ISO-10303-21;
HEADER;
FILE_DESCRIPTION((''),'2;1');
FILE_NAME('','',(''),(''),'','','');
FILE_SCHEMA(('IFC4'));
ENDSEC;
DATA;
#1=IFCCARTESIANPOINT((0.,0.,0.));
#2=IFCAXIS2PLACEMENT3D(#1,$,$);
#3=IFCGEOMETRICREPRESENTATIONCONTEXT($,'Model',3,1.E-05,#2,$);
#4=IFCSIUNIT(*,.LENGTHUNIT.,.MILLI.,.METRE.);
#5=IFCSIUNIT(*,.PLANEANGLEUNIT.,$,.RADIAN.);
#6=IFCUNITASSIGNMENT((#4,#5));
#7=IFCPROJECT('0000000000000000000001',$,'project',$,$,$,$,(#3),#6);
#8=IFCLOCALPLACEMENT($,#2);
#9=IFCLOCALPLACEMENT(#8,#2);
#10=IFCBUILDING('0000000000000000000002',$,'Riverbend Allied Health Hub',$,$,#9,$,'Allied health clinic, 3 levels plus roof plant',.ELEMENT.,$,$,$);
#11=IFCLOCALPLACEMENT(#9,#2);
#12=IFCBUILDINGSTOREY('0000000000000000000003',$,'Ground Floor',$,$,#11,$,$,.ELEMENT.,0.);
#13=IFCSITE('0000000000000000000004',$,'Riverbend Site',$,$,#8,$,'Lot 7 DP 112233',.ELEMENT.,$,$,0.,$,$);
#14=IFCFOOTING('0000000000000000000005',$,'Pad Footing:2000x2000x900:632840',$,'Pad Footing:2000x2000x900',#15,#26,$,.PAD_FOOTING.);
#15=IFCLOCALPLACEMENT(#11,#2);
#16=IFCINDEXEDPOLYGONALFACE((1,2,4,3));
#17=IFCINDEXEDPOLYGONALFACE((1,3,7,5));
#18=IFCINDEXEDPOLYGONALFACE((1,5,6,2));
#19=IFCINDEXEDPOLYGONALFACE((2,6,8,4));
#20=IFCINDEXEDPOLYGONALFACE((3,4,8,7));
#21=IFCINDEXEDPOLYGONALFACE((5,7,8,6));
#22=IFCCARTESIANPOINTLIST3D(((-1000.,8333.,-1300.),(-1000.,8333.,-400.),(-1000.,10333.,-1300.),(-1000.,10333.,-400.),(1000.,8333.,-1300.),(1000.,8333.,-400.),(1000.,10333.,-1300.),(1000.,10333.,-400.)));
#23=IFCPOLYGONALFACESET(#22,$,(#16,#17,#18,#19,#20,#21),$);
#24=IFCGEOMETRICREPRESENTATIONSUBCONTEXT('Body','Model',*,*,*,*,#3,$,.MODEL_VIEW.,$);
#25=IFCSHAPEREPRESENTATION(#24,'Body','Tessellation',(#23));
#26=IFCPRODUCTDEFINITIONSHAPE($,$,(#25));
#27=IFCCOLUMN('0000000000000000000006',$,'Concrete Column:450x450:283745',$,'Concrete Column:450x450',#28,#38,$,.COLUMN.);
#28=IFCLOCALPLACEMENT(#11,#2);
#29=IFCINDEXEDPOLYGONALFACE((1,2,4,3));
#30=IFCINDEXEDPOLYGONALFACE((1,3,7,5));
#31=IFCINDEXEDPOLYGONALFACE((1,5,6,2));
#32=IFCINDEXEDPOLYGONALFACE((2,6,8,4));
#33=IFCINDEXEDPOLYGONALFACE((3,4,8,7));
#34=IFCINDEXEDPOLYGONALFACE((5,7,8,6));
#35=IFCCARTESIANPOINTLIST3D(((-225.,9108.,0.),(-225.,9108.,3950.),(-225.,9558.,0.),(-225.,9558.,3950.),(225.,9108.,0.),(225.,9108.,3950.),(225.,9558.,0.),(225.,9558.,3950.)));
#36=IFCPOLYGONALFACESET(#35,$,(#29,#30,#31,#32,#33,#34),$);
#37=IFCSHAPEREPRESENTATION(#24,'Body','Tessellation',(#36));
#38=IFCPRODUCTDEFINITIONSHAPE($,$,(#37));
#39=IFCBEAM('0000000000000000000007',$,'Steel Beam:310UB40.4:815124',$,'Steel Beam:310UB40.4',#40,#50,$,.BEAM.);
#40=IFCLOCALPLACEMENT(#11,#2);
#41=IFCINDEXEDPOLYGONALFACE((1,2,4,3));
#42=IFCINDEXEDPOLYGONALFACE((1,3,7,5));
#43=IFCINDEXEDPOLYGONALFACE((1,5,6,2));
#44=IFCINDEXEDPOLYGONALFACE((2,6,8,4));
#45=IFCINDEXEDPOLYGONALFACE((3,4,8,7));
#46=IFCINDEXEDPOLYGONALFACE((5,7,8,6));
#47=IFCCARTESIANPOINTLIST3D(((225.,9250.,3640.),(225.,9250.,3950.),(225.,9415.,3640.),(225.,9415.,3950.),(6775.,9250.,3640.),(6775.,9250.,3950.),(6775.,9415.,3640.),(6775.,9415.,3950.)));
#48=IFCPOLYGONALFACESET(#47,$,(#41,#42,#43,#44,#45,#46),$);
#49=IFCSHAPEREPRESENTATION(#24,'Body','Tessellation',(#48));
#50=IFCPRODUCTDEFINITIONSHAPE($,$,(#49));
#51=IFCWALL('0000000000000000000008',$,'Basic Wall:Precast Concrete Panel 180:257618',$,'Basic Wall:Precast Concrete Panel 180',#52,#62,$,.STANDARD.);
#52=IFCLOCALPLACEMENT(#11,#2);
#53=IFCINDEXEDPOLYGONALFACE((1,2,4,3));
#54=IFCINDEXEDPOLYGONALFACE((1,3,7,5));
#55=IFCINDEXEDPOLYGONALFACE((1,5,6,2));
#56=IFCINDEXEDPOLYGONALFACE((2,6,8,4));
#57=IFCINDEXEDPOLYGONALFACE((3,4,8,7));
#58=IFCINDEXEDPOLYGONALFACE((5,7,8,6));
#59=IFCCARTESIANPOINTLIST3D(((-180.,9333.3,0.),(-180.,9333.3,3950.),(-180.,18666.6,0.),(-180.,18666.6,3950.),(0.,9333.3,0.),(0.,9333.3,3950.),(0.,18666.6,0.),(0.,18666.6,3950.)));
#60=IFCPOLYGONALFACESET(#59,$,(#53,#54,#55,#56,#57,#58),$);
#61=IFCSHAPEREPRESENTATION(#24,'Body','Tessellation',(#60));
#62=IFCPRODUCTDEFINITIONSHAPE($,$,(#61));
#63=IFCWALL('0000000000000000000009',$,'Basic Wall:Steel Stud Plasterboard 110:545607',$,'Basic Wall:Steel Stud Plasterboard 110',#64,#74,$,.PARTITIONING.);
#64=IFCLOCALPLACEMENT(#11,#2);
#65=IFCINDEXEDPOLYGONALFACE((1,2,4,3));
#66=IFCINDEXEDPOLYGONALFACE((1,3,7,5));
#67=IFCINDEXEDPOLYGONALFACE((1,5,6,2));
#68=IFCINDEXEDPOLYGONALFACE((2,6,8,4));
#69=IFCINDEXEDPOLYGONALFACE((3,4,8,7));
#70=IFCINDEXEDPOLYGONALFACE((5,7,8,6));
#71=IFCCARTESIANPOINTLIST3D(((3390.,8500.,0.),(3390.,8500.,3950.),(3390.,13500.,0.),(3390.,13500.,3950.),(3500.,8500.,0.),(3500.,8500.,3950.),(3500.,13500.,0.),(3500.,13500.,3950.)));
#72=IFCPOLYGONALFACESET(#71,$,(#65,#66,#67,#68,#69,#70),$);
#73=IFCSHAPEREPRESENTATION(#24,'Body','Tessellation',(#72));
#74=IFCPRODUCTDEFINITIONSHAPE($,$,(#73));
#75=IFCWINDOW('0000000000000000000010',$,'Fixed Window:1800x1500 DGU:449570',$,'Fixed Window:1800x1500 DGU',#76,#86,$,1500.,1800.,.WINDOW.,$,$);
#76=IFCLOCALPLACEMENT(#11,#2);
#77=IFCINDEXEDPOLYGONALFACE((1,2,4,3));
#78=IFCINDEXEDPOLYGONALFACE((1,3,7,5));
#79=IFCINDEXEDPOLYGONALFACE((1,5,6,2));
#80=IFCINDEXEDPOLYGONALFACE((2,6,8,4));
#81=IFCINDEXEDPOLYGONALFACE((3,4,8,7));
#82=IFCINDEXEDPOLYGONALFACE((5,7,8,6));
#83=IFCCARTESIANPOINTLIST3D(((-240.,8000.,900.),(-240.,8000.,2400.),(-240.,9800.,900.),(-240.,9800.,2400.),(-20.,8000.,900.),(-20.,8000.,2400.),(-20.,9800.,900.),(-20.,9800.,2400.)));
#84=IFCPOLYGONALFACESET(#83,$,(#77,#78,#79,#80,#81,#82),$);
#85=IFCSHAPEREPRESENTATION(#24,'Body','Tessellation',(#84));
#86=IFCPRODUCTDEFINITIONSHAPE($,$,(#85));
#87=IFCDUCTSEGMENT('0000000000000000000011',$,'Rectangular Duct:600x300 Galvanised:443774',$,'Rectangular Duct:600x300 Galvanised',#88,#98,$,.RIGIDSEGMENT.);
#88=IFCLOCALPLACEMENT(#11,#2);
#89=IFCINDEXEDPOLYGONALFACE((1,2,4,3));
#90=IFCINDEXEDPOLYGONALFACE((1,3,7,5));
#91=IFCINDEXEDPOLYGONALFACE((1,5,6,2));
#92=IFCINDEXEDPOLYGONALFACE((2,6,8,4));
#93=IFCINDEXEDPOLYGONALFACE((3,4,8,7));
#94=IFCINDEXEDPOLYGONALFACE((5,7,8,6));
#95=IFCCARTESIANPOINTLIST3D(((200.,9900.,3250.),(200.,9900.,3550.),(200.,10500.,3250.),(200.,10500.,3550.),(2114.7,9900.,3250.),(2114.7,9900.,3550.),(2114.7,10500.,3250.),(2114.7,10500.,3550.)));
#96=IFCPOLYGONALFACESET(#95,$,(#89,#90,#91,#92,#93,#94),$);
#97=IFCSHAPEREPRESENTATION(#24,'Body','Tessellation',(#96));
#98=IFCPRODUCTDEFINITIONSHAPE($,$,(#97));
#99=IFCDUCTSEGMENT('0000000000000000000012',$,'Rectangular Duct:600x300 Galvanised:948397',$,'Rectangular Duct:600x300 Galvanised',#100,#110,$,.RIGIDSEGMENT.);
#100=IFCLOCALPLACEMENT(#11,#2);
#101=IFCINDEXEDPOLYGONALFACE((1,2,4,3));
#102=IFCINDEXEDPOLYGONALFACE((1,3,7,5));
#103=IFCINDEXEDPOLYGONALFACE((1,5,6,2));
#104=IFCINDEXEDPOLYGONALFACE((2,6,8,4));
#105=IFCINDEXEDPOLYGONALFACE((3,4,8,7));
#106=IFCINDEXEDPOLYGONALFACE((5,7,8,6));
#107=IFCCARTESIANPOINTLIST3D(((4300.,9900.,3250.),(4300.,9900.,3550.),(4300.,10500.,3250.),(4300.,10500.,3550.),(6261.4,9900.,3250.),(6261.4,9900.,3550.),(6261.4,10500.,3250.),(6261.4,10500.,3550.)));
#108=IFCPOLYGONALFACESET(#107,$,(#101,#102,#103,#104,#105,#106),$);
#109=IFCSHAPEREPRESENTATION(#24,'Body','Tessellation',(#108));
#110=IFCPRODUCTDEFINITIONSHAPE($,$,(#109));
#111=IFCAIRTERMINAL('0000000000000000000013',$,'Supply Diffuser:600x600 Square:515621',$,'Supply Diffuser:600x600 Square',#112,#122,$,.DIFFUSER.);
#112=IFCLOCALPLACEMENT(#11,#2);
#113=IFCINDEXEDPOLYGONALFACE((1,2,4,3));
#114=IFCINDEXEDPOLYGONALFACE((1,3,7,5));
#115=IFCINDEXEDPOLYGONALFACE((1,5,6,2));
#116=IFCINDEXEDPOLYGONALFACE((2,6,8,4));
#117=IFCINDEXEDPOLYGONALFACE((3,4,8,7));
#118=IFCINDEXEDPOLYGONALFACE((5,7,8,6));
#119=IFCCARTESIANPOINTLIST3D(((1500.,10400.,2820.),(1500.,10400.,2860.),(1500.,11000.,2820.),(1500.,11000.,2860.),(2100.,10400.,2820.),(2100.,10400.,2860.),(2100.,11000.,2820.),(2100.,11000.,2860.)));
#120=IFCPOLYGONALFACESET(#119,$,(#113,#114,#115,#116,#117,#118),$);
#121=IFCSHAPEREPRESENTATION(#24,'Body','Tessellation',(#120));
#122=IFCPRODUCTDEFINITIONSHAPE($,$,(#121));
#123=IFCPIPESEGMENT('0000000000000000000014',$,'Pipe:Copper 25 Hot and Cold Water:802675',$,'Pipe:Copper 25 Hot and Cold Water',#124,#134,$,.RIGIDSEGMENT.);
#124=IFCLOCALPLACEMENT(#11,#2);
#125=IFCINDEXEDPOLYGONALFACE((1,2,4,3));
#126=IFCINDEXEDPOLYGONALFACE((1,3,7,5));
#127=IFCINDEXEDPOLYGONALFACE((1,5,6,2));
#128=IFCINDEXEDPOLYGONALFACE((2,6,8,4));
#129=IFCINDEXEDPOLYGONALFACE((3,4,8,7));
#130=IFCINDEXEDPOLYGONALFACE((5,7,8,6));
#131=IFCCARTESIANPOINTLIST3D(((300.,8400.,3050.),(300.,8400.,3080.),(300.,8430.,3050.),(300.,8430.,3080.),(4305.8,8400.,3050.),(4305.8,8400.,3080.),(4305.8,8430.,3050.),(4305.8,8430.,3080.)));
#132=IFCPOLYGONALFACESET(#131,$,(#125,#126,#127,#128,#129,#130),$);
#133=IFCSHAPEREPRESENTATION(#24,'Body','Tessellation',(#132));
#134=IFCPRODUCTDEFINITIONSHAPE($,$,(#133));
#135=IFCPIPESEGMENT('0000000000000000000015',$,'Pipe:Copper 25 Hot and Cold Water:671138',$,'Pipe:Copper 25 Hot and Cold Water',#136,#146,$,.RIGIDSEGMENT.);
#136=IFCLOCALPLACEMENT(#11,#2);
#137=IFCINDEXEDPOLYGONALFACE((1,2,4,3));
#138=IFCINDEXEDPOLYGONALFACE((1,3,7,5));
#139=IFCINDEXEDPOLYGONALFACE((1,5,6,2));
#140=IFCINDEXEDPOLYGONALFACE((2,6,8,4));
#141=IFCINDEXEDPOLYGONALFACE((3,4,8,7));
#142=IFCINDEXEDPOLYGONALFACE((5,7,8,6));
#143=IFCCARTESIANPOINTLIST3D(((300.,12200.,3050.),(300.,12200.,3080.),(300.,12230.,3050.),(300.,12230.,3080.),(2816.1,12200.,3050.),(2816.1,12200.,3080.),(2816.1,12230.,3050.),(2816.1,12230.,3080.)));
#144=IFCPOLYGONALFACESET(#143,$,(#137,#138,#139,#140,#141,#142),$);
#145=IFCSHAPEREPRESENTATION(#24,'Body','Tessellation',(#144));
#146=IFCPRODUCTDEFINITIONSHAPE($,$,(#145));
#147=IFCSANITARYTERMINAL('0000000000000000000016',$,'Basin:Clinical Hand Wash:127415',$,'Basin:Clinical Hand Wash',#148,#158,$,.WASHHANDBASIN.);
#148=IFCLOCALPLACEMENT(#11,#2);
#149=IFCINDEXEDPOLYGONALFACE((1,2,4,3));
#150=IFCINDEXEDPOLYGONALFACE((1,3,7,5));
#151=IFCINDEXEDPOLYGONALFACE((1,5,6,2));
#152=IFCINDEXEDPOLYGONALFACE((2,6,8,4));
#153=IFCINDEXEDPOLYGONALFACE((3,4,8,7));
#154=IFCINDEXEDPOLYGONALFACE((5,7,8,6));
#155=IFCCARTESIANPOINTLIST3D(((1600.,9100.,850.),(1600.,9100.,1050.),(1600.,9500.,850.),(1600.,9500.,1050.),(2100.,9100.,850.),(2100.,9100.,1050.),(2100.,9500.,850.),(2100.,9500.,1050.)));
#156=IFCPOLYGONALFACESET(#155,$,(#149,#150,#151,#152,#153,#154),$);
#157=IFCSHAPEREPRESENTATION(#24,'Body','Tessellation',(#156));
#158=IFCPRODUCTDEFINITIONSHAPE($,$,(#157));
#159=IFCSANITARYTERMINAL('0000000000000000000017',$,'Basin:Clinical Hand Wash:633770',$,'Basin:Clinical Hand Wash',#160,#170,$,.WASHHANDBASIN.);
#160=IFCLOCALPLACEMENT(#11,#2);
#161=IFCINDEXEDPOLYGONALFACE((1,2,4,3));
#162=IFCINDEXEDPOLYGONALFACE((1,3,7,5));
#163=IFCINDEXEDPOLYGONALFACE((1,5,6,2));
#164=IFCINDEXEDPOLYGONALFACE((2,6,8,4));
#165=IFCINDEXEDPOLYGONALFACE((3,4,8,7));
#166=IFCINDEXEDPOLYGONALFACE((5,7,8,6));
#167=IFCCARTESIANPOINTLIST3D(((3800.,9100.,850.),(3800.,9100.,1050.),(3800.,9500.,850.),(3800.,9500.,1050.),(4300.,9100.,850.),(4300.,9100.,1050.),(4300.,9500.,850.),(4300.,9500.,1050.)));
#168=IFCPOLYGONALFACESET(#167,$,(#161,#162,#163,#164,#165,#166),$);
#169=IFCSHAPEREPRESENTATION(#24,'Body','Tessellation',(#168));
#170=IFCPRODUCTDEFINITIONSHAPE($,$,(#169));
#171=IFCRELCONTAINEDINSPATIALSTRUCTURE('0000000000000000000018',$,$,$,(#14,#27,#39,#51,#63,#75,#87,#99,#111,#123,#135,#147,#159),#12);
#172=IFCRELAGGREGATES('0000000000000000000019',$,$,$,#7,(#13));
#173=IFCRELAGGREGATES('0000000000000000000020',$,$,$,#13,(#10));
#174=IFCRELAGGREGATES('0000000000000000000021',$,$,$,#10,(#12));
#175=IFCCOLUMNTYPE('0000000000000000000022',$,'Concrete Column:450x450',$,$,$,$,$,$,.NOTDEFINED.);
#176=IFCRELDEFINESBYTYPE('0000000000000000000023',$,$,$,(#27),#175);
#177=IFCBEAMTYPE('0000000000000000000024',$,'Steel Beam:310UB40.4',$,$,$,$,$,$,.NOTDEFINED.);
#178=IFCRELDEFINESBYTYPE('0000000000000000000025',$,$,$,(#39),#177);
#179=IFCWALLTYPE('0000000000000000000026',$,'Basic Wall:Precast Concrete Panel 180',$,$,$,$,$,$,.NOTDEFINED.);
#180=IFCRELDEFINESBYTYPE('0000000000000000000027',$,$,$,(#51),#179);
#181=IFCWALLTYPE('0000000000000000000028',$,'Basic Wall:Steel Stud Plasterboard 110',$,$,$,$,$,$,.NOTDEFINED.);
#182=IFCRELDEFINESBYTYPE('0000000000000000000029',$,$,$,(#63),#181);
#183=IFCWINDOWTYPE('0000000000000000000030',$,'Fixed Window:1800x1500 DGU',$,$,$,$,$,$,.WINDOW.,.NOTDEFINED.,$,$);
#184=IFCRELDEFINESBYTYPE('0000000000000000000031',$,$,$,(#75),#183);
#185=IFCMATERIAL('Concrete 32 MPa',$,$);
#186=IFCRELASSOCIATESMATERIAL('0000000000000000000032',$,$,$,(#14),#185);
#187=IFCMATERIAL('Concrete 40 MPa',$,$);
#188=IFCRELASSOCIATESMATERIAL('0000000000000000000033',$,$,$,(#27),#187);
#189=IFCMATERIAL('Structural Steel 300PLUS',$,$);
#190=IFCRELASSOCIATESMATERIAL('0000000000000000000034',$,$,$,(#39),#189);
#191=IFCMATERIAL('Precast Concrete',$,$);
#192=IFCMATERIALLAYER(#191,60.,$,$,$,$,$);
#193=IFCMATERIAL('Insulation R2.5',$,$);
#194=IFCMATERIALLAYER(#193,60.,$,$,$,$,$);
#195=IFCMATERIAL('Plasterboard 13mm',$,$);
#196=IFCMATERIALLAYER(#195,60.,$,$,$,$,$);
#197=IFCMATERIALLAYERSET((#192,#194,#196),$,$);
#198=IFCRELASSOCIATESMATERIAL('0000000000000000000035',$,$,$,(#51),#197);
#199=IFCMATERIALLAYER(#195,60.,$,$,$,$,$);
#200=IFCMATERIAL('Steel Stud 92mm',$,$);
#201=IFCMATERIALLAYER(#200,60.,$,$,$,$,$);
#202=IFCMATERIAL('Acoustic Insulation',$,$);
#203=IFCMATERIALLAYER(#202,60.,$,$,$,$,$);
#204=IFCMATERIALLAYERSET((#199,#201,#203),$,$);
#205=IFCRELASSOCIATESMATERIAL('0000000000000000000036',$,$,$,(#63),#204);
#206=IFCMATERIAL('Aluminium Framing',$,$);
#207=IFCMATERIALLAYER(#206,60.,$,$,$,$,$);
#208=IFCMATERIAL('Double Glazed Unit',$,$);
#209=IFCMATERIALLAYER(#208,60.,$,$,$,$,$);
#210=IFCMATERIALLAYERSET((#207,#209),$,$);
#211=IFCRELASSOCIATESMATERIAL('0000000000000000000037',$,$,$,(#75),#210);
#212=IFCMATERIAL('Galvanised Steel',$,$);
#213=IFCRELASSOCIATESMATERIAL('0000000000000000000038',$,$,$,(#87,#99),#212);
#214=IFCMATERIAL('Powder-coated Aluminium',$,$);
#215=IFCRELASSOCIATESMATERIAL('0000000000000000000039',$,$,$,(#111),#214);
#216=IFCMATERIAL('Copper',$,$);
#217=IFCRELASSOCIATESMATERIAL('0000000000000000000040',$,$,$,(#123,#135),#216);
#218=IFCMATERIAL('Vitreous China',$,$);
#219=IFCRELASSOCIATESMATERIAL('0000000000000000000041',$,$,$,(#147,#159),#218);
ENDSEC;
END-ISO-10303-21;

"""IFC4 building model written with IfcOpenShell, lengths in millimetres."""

from ifc_helpers import new_model, si_unit, frame, frame_2d, origin, place, context, subcontext, project, spatial, rectangle, extrude, material, layer, layer_set, layer_usage, type_object, element, save


model = new_model("IFC4")

# Units and contexts
model_context = context("Model", 3, precision=1e-05, world=origin())
body_context = subcontext(model_context, "Body", "Model", "MODEL_VIEW")
ifc_project = project(units=[si_unit("LENGTHUNIT", "METRE", prefix="MILLI"), si_unit("PLANEANGLEUNIT", "RADIAN")], contexts=[model_context])

# Site, building, storey
site_placement = place(None, origin())
site = spatial("IfcSite", under=ifc_project, at=site_placement, Name="Riverbend Site", LongName="Lot 7 DP 112233", CompositionType="ELEMENT", RefElevation=0.0)
building_placement = place(site_placement, origin())
building = spatial("IfcBuilding", under=site, at=building_placement, Name="Riverbend Allied Health Hub", LongName="Allied health clinic, 3 levels plus roof plant", CompositionType="ELEMENT")
storey_placement = place(building_placement, origin())
storey = spatial("IfcBuildingStorey", under=building, at=storey_placement, Name="Ground Floor", CompositionType="ELEMENT", Elevation=0.0)

# Footing
ifc_material_1 = material(Name="Concrete 32 MPa")
footing_placement = place(storey_placement, frame((-1000.0, 8333.0, -1300.0)))
element("IfcFooting", 1, at=footing_placement, inside=storey, material=ifc_material_1, Name="Pad Footing:2000x2000x900:632840", ObjectType="Pad Footing:2000x2000x900", PredefinedType="PAD_FOOTING", context=body_context, shape_type="SweptSolid", body=[
    extrude(rectangle(XDim=2000.0, YDim=2000.0, at=frame_2d((1000.0, 1000.0))), origin(), (0.0, 0.0, 1.0), 900.0),
])

# Column
ifc_material_2 = material(Name="Concrete 40 MPa")
column_type = type_object("IfcColumnType", Name="Concrete Column:450x450", PredefinedType="NOTDEFINED")
column_placement = place(storey_placement, frame((-225.0, 9108.0, 0.0)))
element("IfcColumn", 2, at=column_placement, inside=storey, type_object=column_type, material=ifc_material_2, Name="Concrete Column:450x450:283745", ObjectType="Concrete Column:450x450", PredefinedType="COLUMN", context=body_context, shape_type="SweptSolid", body=[
    extrude(rectangle(XDim=450.0, YDim=450.0, at=frame_2d((225.0, 225.0))), origin(), (0.0, 0.0, 1.0), 3950.0),
])

# Beam
ifc_material_3 = material(Name="Structural Steel 300PLUS")
beam_type = type_object("IfcBeamType", Name="Steel Beam:310UB40.4", PredefinedType="NOTDEFINED")
beam_placement = place(storey_placement, frame((225.0, 9250.0, 3640.0)))
element("IfcBeam", 3, at=beam_placement, inside=storey, type_object=beam_type, material=ifc_material_3, Name="Steel Beam:310UB40.4:815124", ObjectType="Steel Beam:310UB40.4", PredefinedType="BEAM", context=body_context, shape_type="SweptSolid", body=[
    extrude(rectangle(XDim=6550.0, YDim=165.0, at=frame_2d((3275.0, 82.5))), origin(), (0.0, 0.0, 1.0), 310.0),
])

# Walls
ifc_material_4 = material(Name="Precast Concrete")
ifc_layer_1 = layer(ifc_material_4, 60.0)
ifc_material_5 = material(Name="Insulation R2.5")
ifc_layer_2 = layer(ifc_material_5, 60.0)
ifc_material_6 = material(Name="Plasterboard 13mm")
ifc_layer_3 = layer(ifc_material_6, 60.0)
ifc_layer_set_1 = layer_set([ifc_layer_1, ifc_layer_2, ifc_layer_3])
ifc_layer_usage_1 = layer_usage(ifc_layer_set_1, "AXIS2", "POSITIVE", 0.0)
wall_type_1 = type_object("IfcWallType", Name="Basic Wall:Precast Concrete Panel 180", PredefinedType="NOTDEFINED")
wall_1_placement = place(storey_placement, frame((0.0, 9333.3, 0.0), z_axis=(0.0, 0.0, 1.0), x_axis=(0.0, 1.0, 0.0)))
element("IfcWall", 4, at=wall_1_placement, inside=storey, type_object=wall_type_1, material=ifc_layer_usage_1, Name="Basic Wall:Precast Concrete Panel 180:257618", ObjectType="Basic Wall:Precast Concrete Panel 180", PredefinedType="STANDARD", context=body_context, shape_type="SweptSolid", body=[
    extrude(rectangle(XDim=9333.3, YDim=180.0, at=frame_2d((4666.6, 90.0))), origin(), (0.0, 0.0, 1.0), 3950.0),
])
ifc_layer_4 = layer(ifc_material_6, 60.0)
ifc_material_7 = material(Name="Steel Stud 92mm")
ifc_layer_5 = layer(ifc_material_7, 60.0)
ifc_material_8 = material(Name="Acoustic Insulation")
ifc_layer_6 = layer(ifc_material_8, 60.0)
ifc_layer_set_2 = layer_set([ifc_layer_4, ifc_layer_5, ifc_layer_6])
ifc_layer_usage_2 = layer_usage(ifc_layer_set_2, "AXIS2", "POSITIVE", 0.0)
wall_type_2 = type_object("IfcWallType", Name="Basic Wall:Steel Stud Plasterboard 110", PredefinedType="NOTDEFINED")
wall_2_placement = place(storey_placement, frame((3500.0, 8500.0, 0.0), z_axis=(0.0, 0.0, 1.0), x_axis=(0.0, 1.0, 0.0)))
element("IfcWall", 5, at=wall_2_placement, inside=storey, type_object=wall_type_2, material=ifc_layer_usage_2, Name="Basic Wall:Steel Stud Plasterboard 110:545607", ObjectType="Basic Wall:Steel Stud Plasterboard 110", PredefinedType="PARTITIONING", context=body_context, shape_type="SweptSolid", body=[
    extrude(rectangle(XDim=5000.0, YDim=110.0, at=frame_2d((2500.0, 55.0))), origin(), (0.0, 0.0, 1.0), 3950.0),
])

# Window
ifc_material_9 = material(Name="Aluminium Framing")
ifc_layer_7 = layer(ifc_material_9, 60.0)
ifc_material_10 = material(Name="Double Glazed Unit")
ifc_layer_8 = layer(ifc_material_10, 60.0)
ifc_layer_set_3 = layer_set([ifc_layer_7, ifc_layer_8])
ifc_layer_usage_3 = layer_usage(ifc_layer_set_3, "AXIS2", "POSITIVE", 0.0)
window_type = type_object("IfcWindowType", Name="Fixed Window:1800x1500 DGU", PartitioningType="NOTDEFINED", PredefinedType="WINDOW")
window_placement = place(storey_placement, frame((-20.0, 8000.0, 900.0), z_axis=(0.0, 0.0, 1.0), x_axis=(0.0, 1.0, 0.0)))
element("IfcWindow", 6, at=window_placement, inside=storey, type_object=window_type, material=ifc_layer_usage_3, Name="Fixed Window:1800x1500 DGU:449570", ObjectType="Fixed Window:1800x1500 DGU", OverallHeight=1500.0, OverallWidth=1800.0, PredefinedType="WINDOW", context=body_context, shape_type="SweptSolid", body=[
    extrude(rectangle(XDim=1800.0, YDim=220.0, at=frame_2d((900.0, 110.0))), origin(), (0.0, 0.0, 1.0), 1500.0),
])

# Duct segments
ifc_material_11 = material(Name="Galvanised Steel")
duct_segment_1_placement = place(storey_placement, frame((200.0, 9900.0, 3250.0)))
element("IfcDuctSegment", 7, at=duct_segment_1_placement, inside=storey, material=ifc_material_11, Name="Rectangular Duct:600x300 Galvanised:443774", ObjectType="Rectangular Duct:600x300 Galvanised", PredefinedType="RIGIDSEGMENT", context=body_context, shape_type="SweptSolid", body=[
    extrude(rectangle(XDim=1914.7, YDim=600.0, at=frame_2d((957.3, 300.0))), origin(), (0.0, 0.0, 1.0), 300.0),
])
duct_segment_2_placement = place(storey_placement, frame((4300.0, 9900.0, 3250.0)))
element("IfcDuctSegment", 8, at=duct_segment_2_placement, inside=storey, material=ifc_material_11, Name="Rectangular Duct:600x300 Galvanised:948397", ObjectType="Rectangular Duct:600x300 Galvanised", PredefinedType="RIGIDSEGMENT", context=body_context, shape_type="SweptSolid", body=[
    extrude(rectangle(XDim=1961.4, YDim=600.0, at=frame_2d((980.7, 300.0))), origin(), (0.0, 0.0, 1.0), 300.0),
])

# Air terminal
ifc_material_12 = material(Name="Powder-coated Aluminium")
air_terminal_placement = place(storey_placement, frame((1500.0, 10400.0, 2820.0)))
element("IfcAirTerminal", 9, at=air_terminal_placement, inside=storey, material=ifc_material_12, Name="Supply Diffuser:600x600 Square:515621", ObjectType="Supply Diffuser:600x600 Square", PredefinedType="DIFFUSER", context=body_context, shape_type="SweptSolid", body=[
    extrude(rectangle(XDim=600.0, YDim=600.0, at=frame_2d((300.0, 300.0))), origin(), (0.0, 0.0, 1.0), 40.0),
])

# Pipe segments
ifc_material_13 = material(Name="Copper")
pipe_segment_1_placement = place(storey_placement, frame((300.0, 8400.0, 3050.0)))
element("IfcPipeSegment", 10, at=pipe_segment_1_placement, inside=storey, material=ifc_material_13, Name="Pipe:Copper 25 Hot and Cold Water:802675", ObjectType="Pipe:Copper 25 Hot and Cold Water", PredefinedType="RIGIDSEGMENT", context=body_context, shape_type="SweptSolid", body=[
    extrude(rectangle(XDim=4005.8, YDim=30.0, at=frame_2d((2002.9, 15.0))), origin(), (0.0, 0.0, 1.0), 30.0),
])
pipe_segment_2_placement = place(storey_placement, frame((300.0, 12200.0, 3050.0)))
element("IfcPipeSegment", 11, at=pipe_segment_2_placement, inside=storey, material=ifc_material_13, Name="Pipe:Copper 25 Hot and Cold Water:671138", ObjectType="Pipe:Copper 25 Hot and Cold Water", PredefinedType="RIGIDSEGMENT", context=body_context, shape_type="SweptSolid", body=[
    extrude(rectangle(XDim=2516.1, YDim=30.0, at=frame_2d((1258.0, 15.0))), origin(), (0.0, 0.0, 1.0), 30.0),
])

# Sanitary terminals
ifc_material_14 = material(Name="Vitreous China")
for number, where, name in (
    (12, (1600.0, 9100.0, 850.0), "Basin:Clinical Hand Wash:127415"),
    (13, (3800.0, 9100.0, 850.0), "Basin:Clinical Hand Wash:633770"),
):
    element("IfcSanitaryTerminal", number, at=place(storey_placement, frame(where)), inside=storey, material=ifc_material_14, Name=name, ObjectType="Basin:Clinical Hand Wash", PredefinedType="WASHHANDBASIN", context=body_context, shape_type="SweptSolid", body=[
        extrude(rectangle(XDim=500.0, YDim=400.0, at=frame_2d((250.0, 200.0))), origin(), (0.0, 0.0, 1.0), 200.0),
    ])

save(model, "model.ifc")
